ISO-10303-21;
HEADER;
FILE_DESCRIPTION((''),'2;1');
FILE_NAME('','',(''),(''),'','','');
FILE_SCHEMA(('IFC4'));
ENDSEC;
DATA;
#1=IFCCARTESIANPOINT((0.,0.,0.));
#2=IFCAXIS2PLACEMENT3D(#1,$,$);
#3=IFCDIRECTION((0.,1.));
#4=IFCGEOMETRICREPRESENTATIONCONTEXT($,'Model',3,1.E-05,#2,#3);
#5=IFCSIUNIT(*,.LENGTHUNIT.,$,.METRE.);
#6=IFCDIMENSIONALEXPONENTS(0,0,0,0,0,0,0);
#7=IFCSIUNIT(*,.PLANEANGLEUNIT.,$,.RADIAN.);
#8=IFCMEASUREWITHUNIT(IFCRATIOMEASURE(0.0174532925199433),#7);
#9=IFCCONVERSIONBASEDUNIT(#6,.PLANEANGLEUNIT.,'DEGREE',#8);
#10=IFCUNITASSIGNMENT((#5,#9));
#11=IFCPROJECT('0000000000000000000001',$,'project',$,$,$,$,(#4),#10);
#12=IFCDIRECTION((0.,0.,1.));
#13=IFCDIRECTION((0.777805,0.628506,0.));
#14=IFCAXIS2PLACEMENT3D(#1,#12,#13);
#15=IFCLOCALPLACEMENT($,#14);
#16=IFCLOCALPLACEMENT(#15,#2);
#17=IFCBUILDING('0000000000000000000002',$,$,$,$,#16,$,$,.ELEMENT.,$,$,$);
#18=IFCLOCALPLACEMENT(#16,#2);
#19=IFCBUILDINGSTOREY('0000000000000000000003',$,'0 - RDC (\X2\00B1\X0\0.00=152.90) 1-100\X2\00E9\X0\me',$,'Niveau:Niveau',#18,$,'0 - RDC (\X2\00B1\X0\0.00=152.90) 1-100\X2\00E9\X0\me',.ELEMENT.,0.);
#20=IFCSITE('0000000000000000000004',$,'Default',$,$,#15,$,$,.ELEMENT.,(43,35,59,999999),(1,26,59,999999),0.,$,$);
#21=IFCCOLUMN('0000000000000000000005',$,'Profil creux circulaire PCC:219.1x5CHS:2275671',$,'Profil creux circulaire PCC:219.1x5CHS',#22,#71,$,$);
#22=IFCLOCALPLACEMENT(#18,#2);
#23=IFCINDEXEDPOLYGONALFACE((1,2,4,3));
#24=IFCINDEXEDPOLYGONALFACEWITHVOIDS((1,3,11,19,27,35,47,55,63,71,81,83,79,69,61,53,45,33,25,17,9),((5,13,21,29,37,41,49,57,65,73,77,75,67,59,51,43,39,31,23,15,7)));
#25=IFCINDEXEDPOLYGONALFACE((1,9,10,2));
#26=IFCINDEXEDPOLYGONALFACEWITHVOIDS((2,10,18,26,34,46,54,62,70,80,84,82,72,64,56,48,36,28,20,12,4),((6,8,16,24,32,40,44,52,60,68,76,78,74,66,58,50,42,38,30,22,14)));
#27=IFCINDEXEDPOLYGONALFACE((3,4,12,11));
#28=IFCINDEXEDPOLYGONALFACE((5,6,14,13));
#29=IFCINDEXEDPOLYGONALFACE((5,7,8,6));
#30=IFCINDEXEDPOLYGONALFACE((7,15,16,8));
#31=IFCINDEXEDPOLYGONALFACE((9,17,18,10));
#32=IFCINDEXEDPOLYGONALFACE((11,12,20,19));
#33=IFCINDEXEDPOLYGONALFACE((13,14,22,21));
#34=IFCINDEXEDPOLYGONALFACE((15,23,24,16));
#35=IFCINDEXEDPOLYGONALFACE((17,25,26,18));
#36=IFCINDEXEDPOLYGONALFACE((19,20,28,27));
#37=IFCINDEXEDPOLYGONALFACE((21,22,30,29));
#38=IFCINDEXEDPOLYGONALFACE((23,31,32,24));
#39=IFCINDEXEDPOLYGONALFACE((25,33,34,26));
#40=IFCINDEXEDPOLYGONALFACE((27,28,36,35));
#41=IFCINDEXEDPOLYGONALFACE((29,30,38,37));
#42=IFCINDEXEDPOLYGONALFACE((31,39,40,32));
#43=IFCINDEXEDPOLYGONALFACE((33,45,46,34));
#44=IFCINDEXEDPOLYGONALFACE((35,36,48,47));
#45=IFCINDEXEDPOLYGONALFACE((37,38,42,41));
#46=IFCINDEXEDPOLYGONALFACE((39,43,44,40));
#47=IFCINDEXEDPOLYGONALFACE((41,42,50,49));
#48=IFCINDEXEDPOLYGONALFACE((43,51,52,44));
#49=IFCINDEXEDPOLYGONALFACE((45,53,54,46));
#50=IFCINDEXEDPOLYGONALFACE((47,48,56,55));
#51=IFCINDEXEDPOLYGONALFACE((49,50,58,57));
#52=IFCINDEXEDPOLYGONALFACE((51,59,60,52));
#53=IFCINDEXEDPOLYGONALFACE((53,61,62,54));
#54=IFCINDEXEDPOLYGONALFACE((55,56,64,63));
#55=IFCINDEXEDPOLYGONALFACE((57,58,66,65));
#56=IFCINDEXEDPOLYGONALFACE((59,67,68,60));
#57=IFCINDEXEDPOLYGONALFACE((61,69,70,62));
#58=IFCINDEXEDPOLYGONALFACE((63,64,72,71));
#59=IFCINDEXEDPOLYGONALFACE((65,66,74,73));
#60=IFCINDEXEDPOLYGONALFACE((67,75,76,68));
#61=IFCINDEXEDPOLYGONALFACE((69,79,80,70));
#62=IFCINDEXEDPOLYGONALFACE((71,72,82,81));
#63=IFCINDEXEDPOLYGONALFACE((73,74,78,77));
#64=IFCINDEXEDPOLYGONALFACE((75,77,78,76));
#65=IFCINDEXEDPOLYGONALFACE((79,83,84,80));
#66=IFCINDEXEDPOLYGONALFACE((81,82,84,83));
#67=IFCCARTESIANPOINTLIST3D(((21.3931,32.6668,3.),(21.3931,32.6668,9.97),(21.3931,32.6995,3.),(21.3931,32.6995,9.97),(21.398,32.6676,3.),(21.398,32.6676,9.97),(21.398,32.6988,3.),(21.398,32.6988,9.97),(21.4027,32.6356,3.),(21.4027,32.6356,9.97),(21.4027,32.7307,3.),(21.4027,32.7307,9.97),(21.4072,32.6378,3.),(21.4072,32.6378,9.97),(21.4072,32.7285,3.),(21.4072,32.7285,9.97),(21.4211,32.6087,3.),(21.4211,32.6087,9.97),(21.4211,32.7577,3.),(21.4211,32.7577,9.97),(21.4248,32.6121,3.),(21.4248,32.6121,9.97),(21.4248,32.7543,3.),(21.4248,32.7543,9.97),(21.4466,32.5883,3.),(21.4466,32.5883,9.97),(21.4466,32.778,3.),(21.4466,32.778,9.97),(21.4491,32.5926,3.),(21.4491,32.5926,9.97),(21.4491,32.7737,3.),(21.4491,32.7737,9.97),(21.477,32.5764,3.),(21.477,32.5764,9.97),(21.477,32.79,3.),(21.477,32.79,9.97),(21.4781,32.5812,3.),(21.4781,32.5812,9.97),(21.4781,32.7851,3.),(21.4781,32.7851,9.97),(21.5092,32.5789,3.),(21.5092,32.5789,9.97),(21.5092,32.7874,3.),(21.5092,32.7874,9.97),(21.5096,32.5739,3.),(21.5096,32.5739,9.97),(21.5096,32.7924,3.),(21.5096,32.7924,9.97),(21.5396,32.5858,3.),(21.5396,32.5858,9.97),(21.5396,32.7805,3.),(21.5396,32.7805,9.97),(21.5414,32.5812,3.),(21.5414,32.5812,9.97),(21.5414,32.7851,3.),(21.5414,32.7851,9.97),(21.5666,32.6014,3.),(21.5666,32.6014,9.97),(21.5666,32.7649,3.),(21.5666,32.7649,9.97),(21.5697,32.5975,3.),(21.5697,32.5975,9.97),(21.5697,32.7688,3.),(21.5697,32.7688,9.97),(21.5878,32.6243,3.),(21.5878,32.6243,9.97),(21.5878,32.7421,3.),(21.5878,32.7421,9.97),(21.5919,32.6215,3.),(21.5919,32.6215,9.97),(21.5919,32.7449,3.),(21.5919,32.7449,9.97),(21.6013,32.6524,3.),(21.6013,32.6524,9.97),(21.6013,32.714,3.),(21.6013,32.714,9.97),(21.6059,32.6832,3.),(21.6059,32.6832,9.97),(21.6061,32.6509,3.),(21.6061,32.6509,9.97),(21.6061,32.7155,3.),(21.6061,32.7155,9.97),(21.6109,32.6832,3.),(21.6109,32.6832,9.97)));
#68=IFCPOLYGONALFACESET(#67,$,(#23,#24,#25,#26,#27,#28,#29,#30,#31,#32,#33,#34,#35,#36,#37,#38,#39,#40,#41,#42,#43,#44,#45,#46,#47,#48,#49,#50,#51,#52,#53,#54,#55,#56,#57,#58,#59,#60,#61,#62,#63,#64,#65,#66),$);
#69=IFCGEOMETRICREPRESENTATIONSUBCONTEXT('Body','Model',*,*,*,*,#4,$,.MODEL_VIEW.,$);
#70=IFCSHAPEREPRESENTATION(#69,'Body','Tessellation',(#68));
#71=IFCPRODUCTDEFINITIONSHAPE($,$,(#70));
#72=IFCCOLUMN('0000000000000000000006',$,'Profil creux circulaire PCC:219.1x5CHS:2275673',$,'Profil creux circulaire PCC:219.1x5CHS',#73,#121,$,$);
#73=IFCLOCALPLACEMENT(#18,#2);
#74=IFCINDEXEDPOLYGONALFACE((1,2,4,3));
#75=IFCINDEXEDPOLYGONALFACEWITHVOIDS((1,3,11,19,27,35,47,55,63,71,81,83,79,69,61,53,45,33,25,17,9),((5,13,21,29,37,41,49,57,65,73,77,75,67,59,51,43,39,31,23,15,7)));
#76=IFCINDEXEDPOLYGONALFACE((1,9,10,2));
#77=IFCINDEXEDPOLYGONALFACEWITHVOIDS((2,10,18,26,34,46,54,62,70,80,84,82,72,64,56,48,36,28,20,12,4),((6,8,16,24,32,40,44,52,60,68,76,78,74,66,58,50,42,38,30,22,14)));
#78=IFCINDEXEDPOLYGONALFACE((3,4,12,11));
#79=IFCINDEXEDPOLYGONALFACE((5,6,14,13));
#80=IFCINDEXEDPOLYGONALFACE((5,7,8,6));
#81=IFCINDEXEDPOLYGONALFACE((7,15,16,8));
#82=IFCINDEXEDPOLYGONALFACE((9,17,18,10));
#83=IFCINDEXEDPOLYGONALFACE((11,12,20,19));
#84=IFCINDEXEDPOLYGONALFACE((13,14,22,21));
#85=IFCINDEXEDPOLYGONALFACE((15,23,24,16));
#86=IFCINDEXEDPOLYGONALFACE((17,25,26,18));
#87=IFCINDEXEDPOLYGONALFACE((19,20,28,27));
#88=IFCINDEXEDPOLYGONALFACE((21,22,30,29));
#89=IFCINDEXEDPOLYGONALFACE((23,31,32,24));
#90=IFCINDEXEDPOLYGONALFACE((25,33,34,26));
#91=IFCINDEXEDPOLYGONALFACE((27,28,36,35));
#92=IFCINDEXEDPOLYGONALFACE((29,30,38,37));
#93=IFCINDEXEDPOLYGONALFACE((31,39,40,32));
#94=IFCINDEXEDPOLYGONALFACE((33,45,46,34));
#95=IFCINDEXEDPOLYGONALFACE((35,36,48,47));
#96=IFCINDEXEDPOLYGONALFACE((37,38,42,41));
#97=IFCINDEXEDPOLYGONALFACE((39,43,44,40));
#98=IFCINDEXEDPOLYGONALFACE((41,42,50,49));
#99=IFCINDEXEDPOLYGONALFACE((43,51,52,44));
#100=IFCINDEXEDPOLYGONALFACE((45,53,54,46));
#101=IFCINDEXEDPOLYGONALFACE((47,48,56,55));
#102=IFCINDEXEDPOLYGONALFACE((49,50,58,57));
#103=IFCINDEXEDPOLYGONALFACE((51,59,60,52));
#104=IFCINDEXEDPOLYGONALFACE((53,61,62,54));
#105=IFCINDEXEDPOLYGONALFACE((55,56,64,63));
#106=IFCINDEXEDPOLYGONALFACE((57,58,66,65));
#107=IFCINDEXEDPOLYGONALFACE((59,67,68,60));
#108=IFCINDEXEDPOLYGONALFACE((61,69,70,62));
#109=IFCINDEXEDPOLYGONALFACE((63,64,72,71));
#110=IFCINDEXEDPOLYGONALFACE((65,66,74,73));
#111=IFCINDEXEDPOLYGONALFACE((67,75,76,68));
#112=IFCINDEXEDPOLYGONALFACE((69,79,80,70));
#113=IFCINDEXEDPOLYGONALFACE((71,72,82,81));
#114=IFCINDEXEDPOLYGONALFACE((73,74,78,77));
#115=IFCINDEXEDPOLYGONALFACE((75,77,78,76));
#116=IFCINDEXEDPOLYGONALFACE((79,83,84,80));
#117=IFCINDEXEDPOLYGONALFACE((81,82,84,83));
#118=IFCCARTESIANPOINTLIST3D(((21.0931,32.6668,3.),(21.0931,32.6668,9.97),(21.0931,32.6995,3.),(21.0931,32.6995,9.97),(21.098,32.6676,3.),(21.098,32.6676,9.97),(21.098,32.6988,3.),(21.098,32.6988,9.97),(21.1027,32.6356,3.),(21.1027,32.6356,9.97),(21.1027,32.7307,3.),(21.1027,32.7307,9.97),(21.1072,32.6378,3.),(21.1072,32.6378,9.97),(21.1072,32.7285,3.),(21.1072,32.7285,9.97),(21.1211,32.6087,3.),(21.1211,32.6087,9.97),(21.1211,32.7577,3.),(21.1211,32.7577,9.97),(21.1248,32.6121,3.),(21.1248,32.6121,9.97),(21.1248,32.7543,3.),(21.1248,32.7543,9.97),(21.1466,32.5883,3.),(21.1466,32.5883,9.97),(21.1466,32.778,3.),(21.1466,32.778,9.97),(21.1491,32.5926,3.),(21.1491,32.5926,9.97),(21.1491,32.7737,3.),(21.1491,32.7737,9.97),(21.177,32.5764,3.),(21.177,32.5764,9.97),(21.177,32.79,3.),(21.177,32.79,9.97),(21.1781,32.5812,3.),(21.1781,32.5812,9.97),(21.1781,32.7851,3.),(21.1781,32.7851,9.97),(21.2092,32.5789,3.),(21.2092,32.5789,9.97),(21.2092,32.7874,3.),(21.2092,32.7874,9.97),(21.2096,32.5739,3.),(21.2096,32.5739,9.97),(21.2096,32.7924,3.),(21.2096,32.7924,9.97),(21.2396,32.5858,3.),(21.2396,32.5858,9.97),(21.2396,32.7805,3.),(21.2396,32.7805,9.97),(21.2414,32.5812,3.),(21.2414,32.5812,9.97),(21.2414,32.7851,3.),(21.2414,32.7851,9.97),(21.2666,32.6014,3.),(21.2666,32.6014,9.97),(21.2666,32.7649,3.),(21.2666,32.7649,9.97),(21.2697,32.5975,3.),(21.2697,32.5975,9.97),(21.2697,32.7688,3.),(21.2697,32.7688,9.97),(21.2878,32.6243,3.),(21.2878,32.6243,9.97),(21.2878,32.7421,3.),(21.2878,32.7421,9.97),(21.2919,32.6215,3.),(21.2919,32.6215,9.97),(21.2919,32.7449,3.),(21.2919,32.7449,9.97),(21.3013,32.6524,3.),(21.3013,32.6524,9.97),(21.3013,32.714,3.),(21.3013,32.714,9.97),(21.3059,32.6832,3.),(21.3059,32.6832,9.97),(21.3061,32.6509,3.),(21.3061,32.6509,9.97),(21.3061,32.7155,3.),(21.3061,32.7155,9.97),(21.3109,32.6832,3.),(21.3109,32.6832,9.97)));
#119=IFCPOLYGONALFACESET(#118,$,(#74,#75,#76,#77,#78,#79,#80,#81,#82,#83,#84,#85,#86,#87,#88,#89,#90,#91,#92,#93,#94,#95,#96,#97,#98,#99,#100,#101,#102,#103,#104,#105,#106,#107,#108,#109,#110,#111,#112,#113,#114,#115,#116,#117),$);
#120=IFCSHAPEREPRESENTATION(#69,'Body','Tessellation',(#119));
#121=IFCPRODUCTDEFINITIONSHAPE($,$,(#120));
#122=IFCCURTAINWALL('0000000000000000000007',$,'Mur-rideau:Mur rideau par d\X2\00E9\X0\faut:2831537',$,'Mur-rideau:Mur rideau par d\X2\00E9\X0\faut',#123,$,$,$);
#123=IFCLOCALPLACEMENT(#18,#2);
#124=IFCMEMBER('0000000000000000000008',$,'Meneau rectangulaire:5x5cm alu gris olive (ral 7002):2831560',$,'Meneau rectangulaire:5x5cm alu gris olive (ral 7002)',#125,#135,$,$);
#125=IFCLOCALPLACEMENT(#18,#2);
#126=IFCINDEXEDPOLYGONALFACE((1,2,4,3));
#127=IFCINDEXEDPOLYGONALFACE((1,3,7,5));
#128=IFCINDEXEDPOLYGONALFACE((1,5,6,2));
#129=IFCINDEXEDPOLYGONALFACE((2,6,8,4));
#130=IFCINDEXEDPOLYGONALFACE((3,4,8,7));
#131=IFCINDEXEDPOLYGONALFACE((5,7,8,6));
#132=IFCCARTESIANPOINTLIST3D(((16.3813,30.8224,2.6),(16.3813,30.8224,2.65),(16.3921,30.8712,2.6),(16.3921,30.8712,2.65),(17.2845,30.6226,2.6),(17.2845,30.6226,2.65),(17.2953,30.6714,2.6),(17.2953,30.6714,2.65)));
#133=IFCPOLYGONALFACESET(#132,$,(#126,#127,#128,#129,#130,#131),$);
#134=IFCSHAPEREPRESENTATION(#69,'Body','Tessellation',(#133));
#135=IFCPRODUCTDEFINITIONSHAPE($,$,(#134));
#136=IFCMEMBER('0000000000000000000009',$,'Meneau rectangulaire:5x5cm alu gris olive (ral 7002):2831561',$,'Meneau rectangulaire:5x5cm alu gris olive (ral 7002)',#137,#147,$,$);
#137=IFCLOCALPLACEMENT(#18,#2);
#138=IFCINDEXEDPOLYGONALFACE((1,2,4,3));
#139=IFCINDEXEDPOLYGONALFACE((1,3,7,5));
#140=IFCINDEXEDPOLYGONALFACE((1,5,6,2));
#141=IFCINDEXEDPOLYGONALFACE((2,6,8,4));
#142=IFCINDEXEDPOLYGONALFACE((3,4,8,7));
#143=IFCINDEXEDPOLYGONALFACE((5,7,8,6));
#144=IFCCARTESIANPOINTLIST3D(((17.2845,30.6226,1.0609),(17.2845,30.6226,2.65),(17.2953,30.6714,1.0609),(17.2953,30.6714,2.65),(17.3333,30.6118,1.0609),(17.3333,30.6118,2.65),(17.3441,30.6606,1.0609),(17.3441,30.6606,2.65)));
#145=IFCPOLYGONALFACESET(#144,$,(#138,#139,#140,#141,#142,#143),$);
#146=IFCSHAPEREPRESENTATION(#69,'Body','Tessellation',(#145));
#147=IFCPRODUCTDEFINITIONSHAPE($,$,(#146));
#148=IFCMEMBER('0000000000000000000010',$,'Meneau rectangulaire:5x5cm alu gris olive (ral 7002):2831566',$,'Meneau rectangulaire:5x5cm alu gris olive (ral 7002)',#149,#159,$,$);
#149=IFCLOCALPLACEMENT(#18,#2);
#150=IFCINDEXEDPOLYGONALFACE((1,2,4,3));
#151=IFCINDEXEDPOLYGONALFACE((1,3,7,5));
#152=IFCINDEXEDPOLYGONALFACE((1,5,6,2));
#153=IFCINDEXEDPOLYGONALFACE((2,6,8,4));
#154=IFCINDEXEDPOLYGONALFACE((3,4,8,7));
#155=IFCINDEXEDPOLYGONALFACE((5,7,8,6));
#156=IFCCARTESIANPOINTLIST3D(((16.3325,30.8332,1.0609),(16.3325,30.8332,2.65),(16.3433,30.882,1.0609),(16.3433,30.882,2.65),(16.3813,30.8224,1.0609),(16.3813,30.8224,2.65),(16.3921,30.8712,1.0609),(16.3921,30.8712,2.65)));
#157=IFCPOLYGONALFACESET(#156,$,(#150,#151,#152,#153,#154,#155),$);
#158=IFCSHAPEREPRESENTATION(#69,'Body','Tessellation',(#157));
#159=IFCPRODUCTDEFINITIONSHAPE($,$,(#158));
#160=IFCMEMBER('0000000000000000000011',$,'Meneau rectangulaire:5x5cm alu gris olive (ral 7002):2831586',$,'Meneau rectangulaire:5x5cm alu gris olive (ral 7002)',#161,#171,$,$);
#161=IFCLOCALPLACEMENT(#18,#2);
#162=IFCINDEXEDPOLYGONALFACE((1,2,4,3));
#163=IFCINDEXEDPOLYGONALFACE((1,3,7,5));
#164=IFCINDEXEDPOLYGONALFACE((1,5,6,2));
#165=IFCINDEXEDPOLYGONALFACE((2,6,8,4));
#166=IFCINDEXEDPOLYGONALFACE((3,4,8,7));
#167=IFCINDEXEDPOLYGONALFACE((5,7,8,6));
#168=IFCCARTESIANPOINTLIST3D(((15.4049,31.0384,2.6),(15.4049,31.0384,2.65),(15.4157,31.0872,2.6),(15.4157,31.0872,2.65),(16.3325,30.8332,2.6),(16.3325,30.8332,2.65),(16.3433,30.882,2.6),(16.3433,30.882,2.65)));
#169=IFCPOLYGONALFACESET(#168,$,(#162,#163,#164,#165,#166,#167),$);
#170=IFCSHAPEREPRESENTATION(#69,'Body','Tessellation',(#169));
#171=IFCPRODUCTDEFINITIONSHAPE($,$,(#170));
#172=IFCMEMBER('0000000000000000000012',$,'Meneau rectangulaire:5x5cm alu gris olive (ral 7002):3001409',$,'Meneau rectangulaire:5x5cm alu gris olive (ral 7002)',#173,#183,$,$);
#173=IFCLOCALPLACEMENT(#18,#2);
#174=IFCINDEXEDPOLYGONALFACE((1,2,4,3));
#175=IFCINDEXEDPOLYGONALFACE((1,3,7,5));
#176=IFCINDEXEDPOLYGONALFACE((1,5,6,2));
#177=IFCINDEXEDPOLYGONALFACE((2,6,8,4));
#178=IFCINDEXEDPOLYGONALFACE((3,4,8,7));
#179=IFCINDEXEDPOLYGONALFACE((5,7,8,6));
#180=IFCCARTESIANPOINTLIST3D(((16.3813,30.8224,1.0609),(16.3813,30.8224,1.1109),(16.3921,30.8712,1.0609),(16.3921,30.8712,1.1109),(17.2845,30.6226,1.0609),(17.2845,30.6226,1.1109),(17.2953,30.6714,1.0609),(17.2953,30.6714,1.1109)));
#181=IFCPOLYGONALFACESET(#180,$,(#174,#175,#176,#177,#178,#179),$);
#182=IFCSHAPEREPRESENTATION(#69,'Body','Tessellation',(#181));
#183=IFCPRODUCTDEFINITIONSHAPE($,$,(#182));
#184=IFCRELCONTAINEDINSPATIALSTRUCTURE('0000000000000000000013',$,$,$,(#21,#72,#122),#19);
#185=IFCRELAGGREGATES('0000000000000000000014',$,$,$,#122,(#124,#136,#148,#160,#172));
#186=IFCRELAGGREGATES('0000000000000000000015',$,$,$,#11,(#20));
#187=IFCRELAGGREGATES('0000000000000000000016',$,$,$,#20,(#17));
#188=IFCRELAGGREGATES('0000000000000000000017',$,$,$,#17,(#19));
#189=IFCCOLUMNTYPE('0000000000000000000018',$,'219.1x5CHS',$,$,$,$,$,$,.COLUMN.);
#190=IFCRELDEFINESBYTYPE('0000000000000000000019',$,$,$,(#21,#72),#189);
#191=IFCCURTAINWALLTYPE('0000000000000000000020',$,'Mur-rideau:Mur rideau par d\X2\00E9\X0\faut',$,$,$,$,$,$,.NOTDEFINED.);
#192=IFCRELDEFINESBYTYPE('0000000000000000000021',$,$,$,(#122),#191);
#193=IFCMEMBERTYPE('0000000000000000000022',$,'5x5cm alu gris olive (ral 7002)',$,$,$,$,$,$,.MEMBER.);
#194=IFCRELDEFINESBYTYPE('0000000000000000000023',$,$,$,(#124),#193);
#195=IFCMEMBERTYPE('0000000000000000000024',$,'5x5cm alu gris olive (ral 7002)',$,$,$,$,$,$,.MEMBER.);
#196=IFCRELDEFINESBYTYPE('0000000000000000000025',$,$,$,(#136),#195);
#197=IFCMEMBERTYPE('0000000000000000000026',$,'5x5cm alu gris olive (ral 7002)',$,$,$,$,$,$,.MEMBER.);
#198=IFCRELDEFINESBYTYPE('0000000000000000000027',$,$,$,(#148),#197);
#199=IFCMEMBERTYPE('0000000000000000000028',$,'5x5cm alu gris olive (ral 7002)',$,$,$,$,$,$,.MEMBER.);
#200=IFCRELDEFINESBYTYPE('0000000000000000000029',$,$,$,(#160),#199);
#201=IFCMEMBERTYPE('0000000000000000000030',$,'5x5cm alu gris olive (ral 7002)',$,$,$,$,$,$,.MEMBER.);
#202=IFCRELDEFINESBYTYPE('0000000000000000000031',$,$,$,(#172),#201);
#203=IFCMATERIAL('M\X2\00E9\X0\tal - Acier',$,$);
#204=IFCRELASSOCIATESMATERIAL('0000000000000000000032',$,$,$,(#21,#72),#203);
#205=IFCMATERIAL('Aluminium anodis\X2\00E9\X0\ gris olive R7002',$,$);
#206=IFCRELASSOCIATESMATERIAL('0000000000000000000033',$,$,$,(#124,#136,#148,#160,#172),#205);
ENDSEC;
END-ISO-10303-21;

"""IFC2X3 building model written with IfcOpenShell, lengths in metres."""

from ifc_helpers import new_model, entity, si_unit, converted_unit, direction, frame, frame_2d, origin, origin_2d_with_axis, place, context, subcontext, project, spatial, rectangle, hollow_circle, extrude, source, transform, mapped, material, type_object, type_shapes, element, aggregate, save


model = new_model("IFC2X3")

# Units and contexts
model_context = context("Model", 3, precision=1e-05, world=origin(), true_north=direction((0.0, 1.0)))
body_context = subcontext(model_context, "Body", "Model", "MODEL_VIEW")
ifc_project = project(units=[si_unit("LENGTHUNIT", "METRE"), converted_unit("PLANEANGLEUNIT", "DEGREE", entity("IfcRatioMeasure", 0.0174532925199433), si_unit("PLANEANGLEUNIT", "RADIAN"), dimensions=[0, 0, 0, 0, 0, 0, 0])], contexts=[model_context])

# Site, building, storey
site_placement = place(None, frame((0.0, 0.0, 0.0), z_axis=(0.0, 0.0, 1.0), x_axis=(0.777805, 0.628506, 0.0)))
site = spatial("IfcSite", under=ifc_project, at=site_placement, Name="Default", CompositionType="ELEMENT", RefLatitude=(43, 35, 59, 999999), RefLongitude=(1, 26, 59, 999999), RefElevation=0.0)
building_placement = place(site_placement, origin())
building = spatial("IfcBuilding", under=site, at=building_placement, CompositionType="ELEMENT")
storey_placement = place(building_placement, origin())
storey = spatial("IfcBuildingStorey", under=building, at=storey_placement, Name="0 - RDC (±0.00=152.90) 1-100éme", ObjectType="Niveau:Niveau", LongName="0 - RDC (±0.00=152.90) 1-100éme", CompositionType="ELEMENT", Elevation=0.0)

# Columns
ifc_material_1 = material(Name="Métal - Acier")
column_type = type_object("IfcColumnType", Name="219.1x5CHS", PredefinedType="COLUMN")
shared_shape_1 = source(origin(), body_context, "Body", "SweptSolid", [
    extrude(hollow_circle(Radius=0.1095, WallThickness=0.005, at=frame_2d((0.0, 0.0), x_axis=(1.0, 0.0))), frame((0.0, 0.0, 3.0)), (0.0, 0.0, 1.0), 6.97),
])
type_shapes(column_type, [shared_shape_1])
for number, where, name in (
    (1, (21.5014, 32.6832, 0.0), "Profil creux circulaire PCC:219.1x5CHS:2275671"),
    (2, (21.2014, 32.6832, 0.0), "Profil creux circulaire PCC:219.1x5CHS:2275673"),
):
    element("IfcColumn", number, at=place(storey_placement, frame(where)), inside=storey, type_object=column_type, material=ifc_material_1, Name=name, ObjectType="Profil creux circulaire PCC:219.1x5CHS", context=body_context, shape_type="MappedRepresentation", body=[
        mapped(shared_shape_1, transform((0.0, 0.0, 0.0), scale=1.0)),
    ])

# Curtain wall, members
curtain_wall_type = type_object("IfcCurtainWallType", Name="Mur-rideau:Mur rideau par défaut", PredefinedType="NOTDEFINED")
curtain_wall_placement = place(storey_placement, origin())
curtain_wall = element("IfcCurtainWall", 3, at=curtain_wall_placement, inside=storey, type_object=curtain_wall_type, Name="Mur-rideau:Mur rideau par défaut:2831537", ObjectType="Mur-rideau:Mur rideau par défaut")
ifc_material_2 = material(Name="Aluminium anodisé gris olive R7002")
member_type_1 = type_object("IfcMemberType", Name="5x5cm alu gris olive (ral 7002)", PredefinedType="MEMBER")
shared_shape_2 = source(origin(), body_context, "Body", "SweptSolid", [
    extrude(rectangle(XDim=0.05, YDim=0.05, at=origin_2d_with_axis()), frame((-0.025, 0.0, -0.925), z_axis=(0.0, 0.0, 1.0), x_axis=(0.0, -1.0, 0.0)), (0.0, 0.0, 1.0), 0.925),
])
type_shapes(member_type_1, [shared_shape_2])
member_1_placement = place(storey_placement, frame((17.2899, 30.647, 2.65), z_axis=(0.976397, -0.215985, 0.0), x_axis=(0.0, 0.0, 1.0)))
member_1 = element("IfcMember", 4, at=member_1_placement, type_object=member_type_1, material=ifc_material_2, Name="Meneau rectangulaire:5x5cm alu gris olive (ral 7002):2831560", ObjectType="Meneau rectangulaire:5x5cm alu gris olive (ral 7002)", context=body_context, shape_type="MappedRepresentation", body=[
    mapped(shared_shape_2, transform((0.0, 0.0, 0.0), scale=1.0)),
])
member_type_2 = type_object("IfcMemberType", Name="5x5cm alu gris olive (ral 7002)", PredefinedType="MEMBER")
shared_shape_3 = source(origin(), body_context, "Body", "SweptSolid", [
    extrude(rectangle(XDim=0.05, YDim=0.05, at=origin_2d_with_axis()), frame((-0.025, 0.0, -1.5891), z_axis=(0.0, 0.0, 1.0), x_axis=(0.0, -1.0, 0.0)), (0.0, 0.0, 1.0), 1.5891),
])
type_shapes(member_type_2, [shared_shape_3])
member_2_placement = place(storey_placement, frame((17.3387, 30.6362, 1.0609), z_axis=(0.0, 0.0, -1.0), x_axis=(0.976397, -0.215985, 0.0)))
member_2 = element("IfcMember", 5, at=member_2_placement, type_object=member_type_2, material=ifc_material_2, Name="Meneau rectangulaire:5x5cm alu gris olive (ral 7002):2831561", ObjectType="Meneau rectangulaire:5x5cm alu gris olive (ral 7002)", context=body_context, shape_type="MappedRepresentation", body=[
    mapped(shared_shape_3, transform((0.0, 0.0, 0.0), scale=1.0)),
])
member_type_3 = type_object("IfcMemberType", Name="5x5cm alu gris olive (ral 7002)", PredefinedType="MEMBER")
shared_shape_4 = source(origin(), body_context, "Body", "SweptSolid", [
    extrude(rectangle(XDim=0.05, YDim=0.05, at=origin_2d_with_axis()), frame((0.0, 0.0, -1.5891), z_axis=(0.0, 0.0, 1.0), x_axis=(0.0, -1.0, 0.0)), (0.0, 0.0, 1.0), 1.5891),
])
type_shapes(member_type_3, [shared_shape_4])
member_3_placement = place(storey_placement, frame((16.3623, 30.8522, 1.0609), z_axis=(0.0, 0.0, -1.0), x_axis=(0.976397, -0.215985, 0.0)))
member_3 = element("IfcMember", 6, at=member_3_placement, type_object=member_type_3, material=ifc_material_2, Name="Meneau rectangulaire:5x5cm alu gris olive (ral 7002):2831566", ObjectType="Meneau rectangulaire:5x5cm alu gris olive (ral 7002)", context=body_context, shape_type="MappedRepresentation", body=[
    mapped(shared_shape_4, transform((0.0, 0.0, 0.0), scale=1.0)),
])
member_type_4 = type_object("IfcMemberType", Name="5x5cm alu gris olive (ral 7002)", PredefinedType="MEMBER")
shared_shape_5 = source(origin(), body_context, "Body", "SweptSolid", [
    extrude(rectangle(XDim=0.05, YDim=0.05, at=origin_2d_with_axis()), frame((-0.025, 0.0, -0.95), z_axis=(0.0, 0.0, 1.0), x_axis=(0.0, -1.0, 0.0)), (0.0, 0.0, 1.0), 0.95),
])
type_shapes(member_type_4, [shared_shape_5])
member_4_placement = place(storey_placement, frame((16.3379, 30.8576, 2.65), z_axis=(0.976397, -0.215985, 0.0), x_axis=(0.0, 0.0, 1.0)))
member_4 = element("IfcMember", 7, at=member_4_placement, type_object=member_type_4, material=ifc_material_2, Name="Meneau rectangulaire:5x5cm alu gris olive (ral 7002):2831586", ObjectType="Meneau rectangulaire:5x5cm alu gris olive (ral 7002)", context=body_context, shape_type="MappedRepresentation", body=[
    mapped(shared_shape_5, transform((0.0, 0.0, 0.0), scale=1.0)),
])
member_type_5 = type_object("IfcMemberType", Name="5x5cm alu gris olive (ral 7002)", PredefinedType="MEMBER")
shared_shape_6 = source(origin(), body_context, "Body", "SweptSolid", [
    extrude(rectangle(XDim=0.05, YDim=0.05, at=origin_2d_with_axis()), frame((-0.025, 0.0, -0.925), z_axis=(0.0, 0.0, 1.0), x_axis=(0.0, -1.0, 0.0)), (0.0, 0.0, 1.0), 0.925),
])
type_shapes(member_type_5, [shared_shape_6])
member_5_placement = place(storey_placement, frame((16.3867, 30.8468, 1.0609), z_axis=(-0.976397, 0.215985, 0.0), x_axis=(0.0, 0.0, -1.0)))
member_5 = element("IfcMember", 8, at=member_5_placement, type_object=member_type_5, material=ifc_material_2, Name="Meneau rectangulaire:5x5cm alu gris olive (ral 7002):3001409", ObjectType="Meneau rectangulaire:5x5cm alu gris olive (ral 7002)", context=body_context, shape_type="MappedRepresentation", body=[
    mapped(shared_shape_6, transform((0.0, 0.0, 0.0), scale=1.0)),
])

aggregate(curtain_wall, [member_1, member_2, member_3, member_4, member_5])

save(model, "model.ifc")
